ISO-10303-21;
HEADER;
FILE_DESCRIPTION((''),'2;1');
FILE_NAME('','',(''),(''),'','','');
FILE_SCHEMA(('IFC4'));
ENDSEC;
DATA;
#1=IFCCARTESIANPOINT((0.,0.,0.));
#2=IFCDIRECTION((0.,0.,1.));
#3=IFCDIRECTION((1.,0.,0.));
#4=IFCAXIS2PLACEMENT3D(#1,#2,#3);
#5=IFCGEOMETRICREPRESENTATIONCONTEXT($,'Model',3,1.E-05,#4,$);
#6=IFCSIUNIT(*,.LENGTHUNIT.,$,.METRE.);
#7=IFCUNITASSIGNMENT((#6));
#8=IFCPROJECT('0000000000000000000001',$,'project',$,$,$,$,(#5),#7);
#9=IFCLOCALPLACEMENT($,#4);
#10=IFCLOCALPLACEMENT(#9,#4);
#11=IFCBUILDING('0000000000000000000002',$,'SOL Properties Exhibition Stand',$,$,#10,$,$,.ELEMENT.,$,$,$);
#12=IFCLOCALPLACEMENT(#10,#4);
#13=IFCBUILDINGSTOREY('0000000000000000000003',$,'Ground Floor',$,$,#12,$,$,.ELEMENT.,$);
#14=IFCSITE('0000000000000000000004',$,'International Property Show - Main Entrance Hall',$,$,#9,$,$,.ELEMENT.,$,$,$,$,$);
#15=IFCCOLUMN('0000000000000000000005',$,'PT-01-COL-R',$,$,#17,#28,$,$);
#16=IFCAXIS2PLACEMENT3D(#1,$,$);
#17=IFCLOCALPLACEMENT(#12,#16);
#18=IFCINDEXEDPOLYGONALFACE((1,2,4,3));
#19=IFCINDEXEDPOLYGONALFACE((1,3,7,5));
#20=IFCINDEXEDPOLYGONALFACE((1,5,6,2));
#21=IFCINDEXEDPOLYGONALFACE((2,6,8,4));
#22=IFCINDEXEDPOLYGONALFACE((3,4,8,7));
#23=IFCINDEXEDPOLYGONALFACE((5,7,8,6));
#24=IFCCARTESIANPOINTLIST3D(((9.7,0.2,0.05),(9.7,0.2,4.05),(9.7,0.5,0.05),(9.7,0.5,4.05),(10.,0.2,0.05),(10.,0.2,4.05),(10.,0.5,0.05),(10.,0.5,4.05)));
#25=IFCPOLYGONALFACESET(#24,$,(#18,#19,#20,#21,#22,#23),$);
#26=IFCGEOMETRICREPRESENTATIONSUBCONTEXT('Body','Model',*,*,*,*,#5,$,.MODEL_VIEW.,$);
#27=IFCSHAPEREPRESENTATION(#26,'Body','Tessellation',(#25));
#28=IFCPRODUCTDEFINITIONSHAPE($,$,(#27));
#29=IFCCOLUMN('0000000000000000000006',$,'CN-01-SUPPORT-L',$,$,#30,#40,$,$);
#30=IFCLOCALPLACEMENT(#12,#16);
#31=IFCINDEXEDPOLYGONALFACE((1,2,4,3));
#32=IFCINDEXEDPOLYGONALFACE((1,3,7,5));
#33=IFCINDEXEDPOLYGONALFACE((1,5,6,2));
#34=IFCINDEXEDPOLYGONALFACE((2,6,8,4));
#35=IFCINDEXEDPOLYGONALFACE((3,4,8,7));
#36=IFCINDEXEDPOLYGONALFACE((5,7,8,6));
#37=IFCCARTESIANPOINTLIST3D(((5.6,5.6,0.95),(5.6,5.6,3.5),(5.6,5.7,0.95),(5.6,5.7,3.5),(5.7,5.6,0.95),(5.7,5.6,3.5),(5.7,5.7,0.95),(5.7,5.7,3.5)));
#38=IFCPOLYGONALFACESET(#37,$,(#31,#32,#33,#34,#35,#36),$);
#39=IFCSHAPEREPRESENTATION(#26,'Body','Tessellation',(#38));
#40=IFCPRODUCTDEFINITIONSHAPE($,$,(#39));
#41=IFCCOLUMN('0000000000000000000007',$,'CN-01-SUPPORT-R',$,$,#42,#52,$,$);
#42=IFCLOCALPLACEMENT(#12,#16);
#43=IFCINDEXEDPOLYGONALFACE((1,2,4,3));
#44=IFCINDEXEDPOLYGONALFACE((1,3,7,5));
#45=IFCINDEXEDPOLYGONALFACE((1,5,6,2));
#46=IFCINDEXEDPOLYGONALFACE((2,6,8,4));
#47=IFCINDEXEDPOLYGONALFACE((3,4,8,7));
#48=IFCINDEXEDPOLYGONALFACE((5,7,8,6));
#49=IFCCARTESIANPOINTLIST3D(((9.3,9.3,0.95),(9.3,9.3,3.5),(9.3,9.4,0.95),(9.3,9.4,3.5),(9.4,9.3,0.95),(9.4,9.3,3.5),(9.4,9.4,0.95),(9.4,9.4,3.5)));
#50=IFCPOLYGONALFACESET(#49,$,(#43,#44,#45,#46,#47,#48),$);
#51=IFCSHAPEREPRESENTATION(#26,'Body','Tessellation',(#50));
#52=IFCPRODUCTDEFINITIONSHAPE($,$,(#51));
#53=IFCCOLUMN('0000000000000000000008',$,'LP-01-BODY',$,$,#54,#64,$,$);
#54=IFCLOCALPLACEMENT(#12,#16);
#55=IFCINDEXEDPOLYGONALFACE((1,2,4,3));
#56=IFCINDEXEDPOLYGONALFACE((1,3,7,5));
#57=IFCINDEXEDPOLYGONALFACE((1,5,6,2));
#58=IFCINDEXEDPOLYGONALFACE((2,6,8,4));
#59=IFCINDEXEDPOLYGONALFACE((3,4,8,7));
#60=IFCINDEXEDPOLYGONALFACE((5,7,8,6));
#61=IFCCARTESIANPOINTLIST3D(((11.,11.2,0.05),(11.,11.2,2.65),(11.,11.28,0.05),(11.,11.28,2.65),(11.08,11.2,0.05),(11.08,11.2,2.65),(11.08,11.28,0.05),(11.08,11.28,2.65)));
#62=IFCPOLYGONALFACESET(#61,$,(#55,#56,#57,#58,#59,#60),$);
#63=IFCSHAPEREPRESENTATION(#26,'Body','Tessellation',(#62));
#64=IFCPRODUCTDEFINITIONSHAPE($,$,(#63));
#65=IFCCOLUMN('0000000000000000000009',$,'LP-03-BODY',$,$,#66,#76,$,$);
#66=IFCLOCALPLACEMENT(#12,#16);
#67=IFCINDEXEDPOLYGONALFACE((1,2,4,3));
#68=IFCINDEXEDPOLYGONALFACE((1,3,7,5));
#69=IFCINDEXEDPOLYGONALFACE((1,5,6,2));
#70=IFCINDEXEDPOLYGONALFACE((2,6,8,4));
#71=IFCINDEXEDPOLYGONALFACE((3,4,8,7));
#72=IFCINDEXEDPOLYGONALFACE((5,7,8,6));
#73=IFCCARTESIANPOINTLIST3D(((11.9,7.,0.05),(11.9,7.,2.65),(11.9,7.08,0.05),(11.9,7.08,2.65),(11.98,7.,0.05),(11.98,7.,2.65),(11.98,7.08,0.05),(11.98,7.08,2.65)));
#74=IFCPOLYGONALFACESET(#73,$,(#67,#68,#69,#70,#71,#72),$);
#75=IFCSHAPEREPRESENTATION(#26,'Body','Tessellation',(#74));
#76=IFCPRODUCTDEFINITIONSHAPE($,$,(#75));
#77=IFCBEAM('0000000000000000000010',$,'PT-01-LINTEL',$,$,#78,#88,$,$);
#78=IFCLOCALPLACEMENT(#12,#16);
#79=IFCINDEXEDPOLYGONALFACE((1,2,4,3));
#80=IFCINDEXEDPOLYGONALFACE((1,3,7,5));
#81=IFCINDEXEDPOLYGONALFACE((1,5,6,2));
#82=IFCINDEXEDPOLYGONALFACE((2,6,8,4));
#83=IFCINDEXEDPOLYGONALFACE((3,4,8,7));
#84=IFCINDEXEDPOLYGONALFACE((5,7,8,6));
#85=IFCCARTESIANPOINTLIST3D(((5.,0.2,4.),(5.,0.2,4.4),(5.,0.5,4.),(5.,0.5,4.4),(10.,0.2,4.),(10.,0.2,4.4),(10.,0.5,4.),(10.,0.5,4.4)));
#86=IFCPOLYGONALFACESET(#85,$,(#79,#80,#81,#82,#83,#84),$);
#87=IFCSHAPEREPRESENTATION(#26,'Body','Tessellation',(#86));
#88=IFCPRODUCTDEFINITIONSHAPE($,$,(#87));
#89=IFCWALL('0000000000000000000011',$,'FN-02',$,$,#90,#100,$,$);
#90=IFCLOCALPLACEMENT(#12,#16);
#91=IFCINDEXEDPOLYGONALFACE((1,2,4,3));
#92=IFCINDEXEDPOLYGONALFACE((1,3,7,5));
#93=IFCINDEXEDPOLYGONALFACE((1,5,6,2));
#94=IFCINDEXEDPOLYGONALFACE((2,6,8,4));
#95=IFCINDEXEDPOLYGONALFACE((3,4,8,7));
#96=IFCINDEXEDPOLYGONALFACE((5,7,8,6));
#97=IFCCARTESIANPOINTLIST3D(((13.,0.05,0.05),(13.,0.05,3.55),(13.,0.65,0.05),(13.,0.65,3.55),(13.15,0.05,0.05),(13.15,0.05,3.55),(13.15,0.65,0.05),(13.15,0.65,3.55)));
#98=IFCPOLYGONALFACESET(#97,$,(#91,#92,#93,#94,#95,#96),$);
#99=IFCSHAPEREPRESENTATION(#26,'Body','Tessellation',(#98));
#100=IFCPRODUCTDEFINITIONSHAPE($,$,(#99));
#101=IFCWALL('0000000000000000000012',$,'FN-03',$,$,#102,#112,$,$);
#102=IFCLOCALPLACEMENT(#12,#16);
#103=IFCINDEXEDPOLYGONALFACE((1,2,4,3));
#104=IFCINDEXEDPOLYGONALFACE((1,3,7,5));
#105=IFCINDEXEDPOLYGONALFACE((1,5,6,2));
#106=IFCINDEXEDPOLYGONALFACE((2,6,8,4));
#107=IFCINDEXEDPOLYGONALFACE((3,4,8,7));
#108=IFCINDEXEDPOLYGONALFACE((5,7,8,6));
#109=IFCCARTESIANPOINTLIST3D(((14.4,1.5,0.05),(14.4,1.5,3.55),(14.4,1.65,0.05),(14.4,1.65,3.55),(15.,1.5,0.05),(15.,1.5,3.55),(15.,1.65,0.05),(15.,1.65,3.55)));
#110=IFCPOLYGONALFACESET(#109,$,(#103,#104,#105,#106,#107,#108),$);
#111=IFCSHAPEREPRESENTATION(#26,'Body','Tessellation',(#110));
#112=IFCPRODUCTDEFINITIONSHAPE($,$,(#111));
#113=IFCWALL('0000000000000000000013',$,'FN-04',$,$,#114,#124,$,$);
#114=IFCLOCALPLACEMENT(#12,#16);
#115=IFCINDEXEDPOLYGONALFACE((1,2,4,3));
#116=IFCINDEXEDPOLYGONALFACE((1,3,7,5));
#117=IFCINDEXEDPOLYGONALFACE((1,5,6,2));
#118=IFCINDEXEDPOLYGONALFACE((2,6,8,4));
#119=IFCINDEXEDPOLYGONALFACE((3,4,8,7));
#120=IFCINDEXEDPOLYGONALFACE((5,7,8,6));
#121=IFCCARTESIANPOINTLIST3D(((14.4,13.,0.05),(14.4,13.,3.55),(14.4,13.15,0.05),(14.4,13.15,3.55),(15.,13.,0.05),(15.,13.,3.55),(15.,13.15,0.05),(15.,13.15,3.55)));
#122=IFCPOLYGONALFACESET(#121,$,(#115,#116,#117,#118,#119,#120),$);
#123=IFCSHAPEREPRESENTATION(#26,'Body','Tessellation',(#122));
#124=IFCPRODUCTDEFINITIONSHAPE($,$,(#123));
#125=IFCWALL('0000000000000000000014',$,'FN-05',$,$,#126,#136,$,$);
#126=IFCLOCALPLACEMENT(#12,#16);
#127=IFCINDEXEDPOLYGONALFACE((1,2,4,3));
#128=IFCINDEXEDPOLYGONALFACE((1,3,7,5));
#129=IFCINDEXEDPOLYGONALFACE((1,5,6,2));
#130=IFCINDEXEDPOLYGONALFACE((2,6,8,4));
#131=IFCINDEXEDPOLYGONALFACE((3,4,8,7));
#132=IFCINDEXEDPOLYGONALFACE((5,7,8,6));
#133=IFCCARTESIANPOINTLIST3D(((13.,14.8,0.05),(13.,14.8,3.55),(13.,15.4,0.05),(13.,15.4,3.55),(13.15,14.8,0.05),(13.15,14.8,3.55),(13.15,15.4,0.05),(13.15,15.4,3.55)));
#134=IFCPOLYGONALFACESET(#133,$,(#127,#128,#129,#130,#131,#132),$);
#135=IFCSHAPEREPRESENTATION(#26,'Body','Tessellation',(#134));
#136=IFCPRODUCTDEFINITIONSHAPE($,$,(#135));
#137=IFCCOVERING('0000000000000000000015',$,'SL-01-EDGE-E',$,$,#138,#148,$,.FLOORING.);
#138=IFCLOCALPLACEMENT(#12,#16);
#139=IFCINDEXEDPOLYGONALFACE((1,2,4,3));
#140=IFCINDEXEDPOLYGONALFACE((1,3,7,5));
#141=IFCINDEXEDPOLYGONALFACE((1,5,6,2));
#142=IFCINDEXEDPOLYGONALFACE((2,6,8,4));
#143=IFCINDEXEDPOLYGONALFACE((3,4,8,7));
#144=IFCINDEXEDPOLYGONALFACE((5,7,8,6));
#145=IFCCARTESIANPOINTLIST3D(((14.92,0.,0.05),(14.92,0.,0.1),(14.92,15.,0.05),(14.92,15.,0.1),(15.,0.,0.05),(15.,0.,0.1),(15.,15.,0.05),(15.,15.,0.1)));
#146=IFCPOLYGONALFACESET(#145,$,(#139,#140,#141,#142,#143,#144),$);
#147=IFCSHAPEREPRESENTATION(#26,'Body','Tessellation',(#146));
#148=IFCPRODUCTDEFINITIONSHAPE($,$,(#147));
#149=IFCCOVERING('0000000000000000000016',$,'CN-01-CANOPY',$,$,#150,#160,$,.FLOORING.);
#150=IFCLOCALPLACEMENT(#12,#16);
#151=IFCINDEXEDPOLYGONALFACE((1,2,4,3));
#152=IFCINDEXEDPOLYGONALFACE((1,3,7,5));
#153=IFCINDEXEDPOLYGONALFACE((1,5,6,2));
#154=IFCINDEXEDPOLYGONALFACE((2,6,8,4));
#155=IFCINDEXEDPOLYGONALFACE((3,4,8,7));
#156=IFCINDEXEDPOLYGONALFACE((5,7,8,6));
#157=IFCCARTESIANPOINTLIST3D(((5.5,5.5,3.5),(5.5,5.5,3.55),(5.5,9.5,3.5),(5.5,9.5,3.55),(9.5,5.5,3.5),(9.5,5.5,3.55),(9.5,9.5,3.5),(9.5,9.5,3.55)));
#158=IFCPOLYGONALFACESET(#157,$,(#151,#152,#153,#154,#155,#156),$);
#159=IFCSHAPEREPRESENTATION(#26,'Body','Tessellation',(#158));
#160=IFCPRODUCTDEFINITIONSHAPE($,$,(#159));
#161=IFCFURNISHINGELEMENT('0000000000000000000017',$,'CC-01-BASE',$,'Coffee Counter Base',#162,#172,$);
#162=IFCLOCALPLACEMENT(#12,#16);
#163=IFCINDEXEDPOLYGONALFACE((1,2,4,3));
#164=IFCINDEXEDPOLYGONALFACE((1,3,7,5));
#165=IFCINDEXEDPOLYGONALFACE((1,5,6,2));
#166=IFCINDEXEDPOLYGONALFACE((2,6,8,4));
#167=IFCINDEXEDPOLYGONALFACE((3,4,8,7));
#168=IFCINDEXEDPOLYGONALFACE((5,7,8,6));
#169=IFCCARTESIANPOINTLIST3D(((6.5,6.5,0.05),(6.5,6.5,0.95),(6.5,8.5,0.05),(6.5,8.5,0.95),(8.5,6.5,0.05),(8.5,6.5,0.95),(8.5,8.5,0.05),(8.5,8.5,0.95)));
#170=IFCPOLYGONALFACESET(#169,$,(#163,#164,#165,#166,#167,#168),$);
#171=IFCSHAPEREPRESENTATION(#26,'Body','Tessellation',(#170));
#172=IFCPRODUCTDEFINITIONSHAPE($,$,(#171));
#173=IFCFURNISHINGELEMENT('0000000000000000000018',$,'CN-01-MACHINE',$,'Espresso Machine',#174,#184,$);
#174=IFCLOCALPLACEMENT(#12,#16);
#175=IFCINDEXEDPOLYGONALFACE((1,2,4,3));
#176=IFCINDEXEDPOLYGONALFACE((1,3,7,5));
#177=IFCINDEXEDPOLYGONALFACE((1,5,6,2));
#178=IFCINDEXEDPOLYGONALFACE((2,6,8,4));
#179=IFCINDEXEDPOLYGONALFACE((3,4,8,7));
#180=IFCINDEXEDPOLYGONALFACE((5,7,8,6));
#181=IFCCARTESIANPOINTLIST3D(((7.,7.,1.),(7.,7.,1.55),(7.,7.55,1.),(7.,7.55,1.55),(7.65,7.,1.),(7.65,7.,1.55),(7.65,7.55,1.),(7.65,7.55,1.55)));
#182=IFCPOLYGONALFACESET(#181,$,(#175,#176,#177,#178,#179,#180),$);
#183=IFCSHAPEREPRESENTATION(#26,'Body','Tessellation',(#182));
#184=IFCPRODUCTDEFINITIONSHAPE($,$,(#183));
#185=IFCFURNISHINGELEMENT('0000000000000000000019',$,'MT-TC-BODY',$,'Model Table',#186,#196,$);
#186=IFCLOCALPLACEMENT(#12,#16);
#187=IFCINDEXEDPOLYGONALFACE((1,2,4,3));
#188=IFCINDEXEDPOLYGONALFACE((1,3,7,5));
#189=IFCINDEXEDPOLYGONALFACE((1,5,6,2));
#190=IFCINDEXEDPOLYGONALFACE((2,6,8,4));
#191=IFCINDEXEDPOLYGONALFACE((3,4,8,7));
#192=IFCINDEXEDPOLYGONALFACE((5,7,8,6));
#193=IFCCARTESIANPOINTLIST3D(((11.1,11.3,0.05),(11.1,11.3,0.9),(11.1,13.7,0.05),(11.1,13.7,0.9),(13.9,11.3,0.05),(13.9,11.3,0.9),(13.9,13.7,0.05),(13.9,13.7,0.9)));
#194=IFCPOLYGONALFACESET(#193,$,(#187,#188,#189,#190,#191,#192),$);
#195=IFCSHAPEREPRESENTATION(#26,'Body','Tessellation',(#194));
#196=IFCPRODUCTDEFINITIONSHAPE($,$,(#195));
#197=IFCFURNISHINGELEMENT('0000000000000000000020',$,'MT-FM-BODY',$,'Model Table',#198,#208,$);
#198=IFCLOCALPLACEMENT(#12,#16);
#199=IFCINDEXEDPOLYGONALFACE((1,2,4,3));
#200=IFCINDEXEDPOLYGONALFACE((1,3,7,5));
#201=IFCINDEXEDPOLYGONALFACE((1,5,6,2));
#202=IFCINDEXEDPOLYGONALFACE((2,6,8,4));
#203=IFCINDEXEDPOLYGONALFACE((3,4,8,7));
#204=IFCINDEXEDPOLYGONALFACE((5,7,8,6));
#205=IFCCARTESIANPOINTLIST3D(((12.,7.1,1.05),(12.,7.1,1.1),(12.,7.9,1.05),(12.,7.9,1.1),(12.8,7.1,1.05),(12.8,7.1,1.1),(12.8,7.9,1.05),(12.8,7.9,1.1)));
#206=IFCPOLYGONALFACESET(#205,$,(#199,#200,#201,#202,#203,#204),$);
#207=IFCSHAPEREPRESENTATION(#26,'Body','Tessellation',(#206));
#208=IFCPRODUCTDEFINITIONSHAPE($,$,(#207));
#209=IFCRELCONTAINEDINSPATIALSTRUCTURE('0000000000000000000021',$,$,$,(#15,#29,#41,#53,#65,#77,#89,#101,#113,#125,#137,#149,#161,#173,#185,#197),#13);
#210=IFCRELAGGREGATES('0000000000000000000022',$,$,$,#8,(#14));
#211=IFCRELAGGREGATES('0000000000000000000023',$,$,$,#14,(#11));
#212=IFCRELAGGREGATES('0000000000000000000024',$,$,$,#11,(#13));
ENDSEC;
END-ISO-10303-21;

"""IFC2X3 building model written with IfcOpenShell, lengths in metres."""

from ifc_helpers import new_model, si_unit, frame, frame_2d, origin, origin_with_axes, place, context, subcontext, project, spatial, rectangle, extrude, element, save


model = new_model("IFC2X3")

# Units and contexts
model_context = context("Model", 3, precision=1e-05, world=origin_with_axes())
body_context = subcontext(model_context, "Body", "Model", "MODEL_VIEW")
ifc_project = project(units=[si_unit("LENGTHUNIT", "METRE")], contexts=[model_context])

# Site, building, storey
site_placement = place(None, origin_with_axes())
site = spatial("IfcSite", under=ifc_project, at=site_placement, Name="International Property Show - Main Entrance Hall", CompositionType="ELEMENT")
building_placement = place(site_placement, origin_with_axes())
building = spatial("IfcBuilding", under=site, at=building_placement, Name="SOL Properties Exhibition Stand", CompositionType="ELEMENT")
storey_placement = place(building_placement, origin_with_axes())
storey = spatial("IfcBuildingStorey", under=building, at=storey_placement, Name="Ground Floor", CompositionType="ELEMENT")

# Columns
column_placement = place(storey_placement, frame((9.7, 0.2, 0.05), z_axis=(0.0, 0.0, 1.0), x_axis=(1.0, 0.0, 0.0)))
element("IfcColumn", 1, at=column_placement, inside=storey, Name="PT-01-COL-R", context=body_context, shape_type="SweptSolid", body=[
    extrude(rectangle(XDim=0.3, YDim=0.3, at=frame_2d((0.15, 0.15))), origin(), (0.0, 0.0, 1.0), 4.0),
])
for number, where, z_axis, x_axis, name in (
    (2, (5.6, 5.6, 0.95), (0.0, 0.0, 1.0), (1.0, 0.0, 0.0), "CN-01-SUPPORT-L"),
    (3, (9.3, 9.3, 0.95), (0.0, 0.0, 1.0), (1.0, 0.0, 0.0), "CN-01-SUPPORT-R"),
):
    element("IfcColumn", number, at=place(storey_placement, frame(where, z_axis=z_axis, x_axis=x_axis)), inside=storey, Name=name, context=body_context, shape_type="SweptSolid", body=[
        extrude(rectangle(XDim=0.1, YDim=0.1, at=frame_2d((0.05, 0.05))), origin(), (0.0, 0.0, 1.0), 2.55),
    ])
for number, where, z_axis, x_axis, name in (
    (4, (11.0, 11.2, 0.05), (0.0, 0.0, 1.0), (1.0, 0.0, 0.0), "LP-01-BODY"),
    (5, (11.9, 7.0, 0.05), (0.0, 0.0, 1.0), (1.0, 0.0, 0.0), "LP-03-BODY"),
):
    element("IfcColumn", number, at=place(storey_placement, frame(where, z_axis=z_axis, x_axis=x_axis)), inside=storey, Name=name, context=body_context, shape_type="SweptSolid", body=[
        extrude(rectangle(XDim=0.08, YDim=0.08, at=frame_2d((0.04, 0.04))), origin(), (0.0, 0.0, 1.0), 2.6),
    ])

# Beam
beam_placement = place(storey_placement, frame((5.0, 0.2, 4.0), z_axis=(0.0, 0.0, 1.0), x_axis=(1.0, 0.0, 0.0)))
element("IfcBeam", 6, at=beam_placement, inside=storey, Name="PT-01-LINTEL", context=body_context, shape_type="SweptSolid", body=[
    extrude(rectangle(XDim=5.0, YDim=0.3, at=frame_2d((2.5, 0.15))), origin(), (0.0, 0.0, 1.0), 0.4),
])

# Walls
wall_1_placement = place(storey_placement, frame((13.0, 0.05, 0.05), z_axis=(0.0, 0.0, 1.0), x_axis=(1.0, 0.0, 0.0)))
element("IfcWall", 7, at=wall_1_placement, inside=storey, Name="FN-02", context=body_context, shape_type="SweptSolid", body=[
    extrude(rectangle(XDim=0.15, YDim=0.6, at=frame_2d((0.075, 0.3))), origin(), (0.0, 0.0, 1.0), 3.5),
])
for number, where, z_axis, x_axis, name in (
    (8, (14.4, 1.5, 0.05), (0.0, 0.0, 1.0), (1.0, 0.0, 0.0), "FN-03"),
    (9, (14.4, 13.0, 0.05), (0.0, 0.0, 1.0), (1.0, 0.0, 0.0), "FN-04"),
):
    element("IfcWall", number, at=place(storey_placement, frame(where, z_axis=z_axis, x_axis=x_axis)), inside=storey, Name=name, context=body_context, shape_type="SweptSolid", body=[
        extrude(rectangle(XDim=0.6, YDim=0.15, at=frame_2d((0.3, 0.075))), origin(), (0.0, 0.0, 1.0), 3.5),
    ])
wall_2_placement = place(storey_placement, frame((13.0, 14.8, 0.05), z_axis=(0.0, 0.0, 1.0), x_axis=(1.0, 0.0, 0.0)))
element("IfcWall", 10, at=wall_2_placement, inside=storey, Name="FN-05", context=body_context, shape_type="SweptSolid", body=[
    extrude(rectangle(XDim=0.15, YDim=0.6, at=frame_2d((0.075, 0.3))), origin(), (0.0, 0.0, 1.0), 3.5),
])

# Coverings
covering_1_placement = place(storey_placement, frame((14.92, 0.0, 0.05), z_axis=(0.0, 0.0, 1.0), x_axis=(1.0, 0.0, 0.0)))
element("IfcCovering", 11, at=covering_1_placement, inside=storey, Name="SL-01-EDGE-E", PredefinedType="FLOORING", context=body_context, shape_type="SweptSolid", body=[
    extrude(rectangle(XDim=0.08, YDim=15.0, at=frame_2d((0.04, 7.5))), origin(), (0.0, 0.0, 1.0), 0.05),
])
covering_2_placement = place(storey_placement, frame((5.5, 5.5, 3.5), z_axis=(0.0, 0.0, 1.0), x_axis=(1.0, 0.0, 0.0)))
element("IfcCovering", 12, at=covering_2_placement, inside=storey, Name="CN-01-CANOPY", PredefinedType="FLOORING", context=body_context, shape_type="SweptSolid", body=[
    extrude(rectangle(XDim=4.0, YDim=4.0, at=frame_2d((2.0, 2.0))), origin(), (0.0, 0.0, 1.0), 0.05),
])

# Furnishing elements
furnishing_1_placement = place(storey_placement, frame((6.5, 6.5, 0.05), z_axis=(0.0, 0.0, 1.0), x_axis=(1.0, 0.0, 0.0)))
element("IfcFurnishingElement", 13, at=furnishing_1_placement, inside=storey, Name="CC-01-BASE", ObjectType="Coffee Counter Base", context=body_context, shape_type="SweptSolid", body=[
    extrude(rectangle(XDim=2.0, YDim=2.0, at=frame_2d((1.0, 1.0))), origin(), (0.0, 0.0, 1.0), 0.9),
])
furnishing_2_placement = place(storey_placement, frame((7.0, 7.0, 1.0), z_axis=(0.0, 0.0, 1.0), x_axis=(1.0, 0.0, 0.0)))
element("IfcFurnishingElement", 14, at=furnishing_2_placement, inside=storey, Name="CN-01-MACHINE", ObjectType="Espresso Machine", context=body_context, shape_type="SweptSolid", body=[
    extrude(rectangle(XDim=0.65, YDim=0.55, at=frame_2d((0.325, 0.275))), origin(), (0.0, 0.0, 1.0), 0.55),
])
furnishing_3_placement = place(storey_placement, frame((11.1, 11.3, 0.05), z_axis=(0.0, 0.0, 1.0), x_axis=(1.0, 0.0, 0.0)))
element("IfcFurnishingElement", 15, at=furnishing_3_placement, inside=storey, Name="MT-TC-BODY", ObjectType="Model Table", context=body_context, shape_type="SweptSolid", body=[
    extrude(rectangle(XDim=2.8, YDim=2.4, at=frame_2d((1.4, 1.2))), origin(), (0.0, 0.0, 1.0), 0.85),
])
furnishing_4_placement = place(storey_placement, frame((12.0, 7.1, 1.05), z_axis=(0.0, 0.0, 1.0), x_axis=(1.0, 0.0, 0.0)))
element("IfcFurnishingElement", 16, at=furnishing_4_placement, inside=storey, Name="MT-FM-BODY", ObjectType="Model Table", context=body_context, shape_type="SweptSolid", body=[
    extrude(rectangle(XDim=0.8, YDim=0.8, at=frame_2d((0.4, 0.4))), origin(), (0.0, 0.0, 1.0), 0.05),
])

save(model, "model.ifc")
